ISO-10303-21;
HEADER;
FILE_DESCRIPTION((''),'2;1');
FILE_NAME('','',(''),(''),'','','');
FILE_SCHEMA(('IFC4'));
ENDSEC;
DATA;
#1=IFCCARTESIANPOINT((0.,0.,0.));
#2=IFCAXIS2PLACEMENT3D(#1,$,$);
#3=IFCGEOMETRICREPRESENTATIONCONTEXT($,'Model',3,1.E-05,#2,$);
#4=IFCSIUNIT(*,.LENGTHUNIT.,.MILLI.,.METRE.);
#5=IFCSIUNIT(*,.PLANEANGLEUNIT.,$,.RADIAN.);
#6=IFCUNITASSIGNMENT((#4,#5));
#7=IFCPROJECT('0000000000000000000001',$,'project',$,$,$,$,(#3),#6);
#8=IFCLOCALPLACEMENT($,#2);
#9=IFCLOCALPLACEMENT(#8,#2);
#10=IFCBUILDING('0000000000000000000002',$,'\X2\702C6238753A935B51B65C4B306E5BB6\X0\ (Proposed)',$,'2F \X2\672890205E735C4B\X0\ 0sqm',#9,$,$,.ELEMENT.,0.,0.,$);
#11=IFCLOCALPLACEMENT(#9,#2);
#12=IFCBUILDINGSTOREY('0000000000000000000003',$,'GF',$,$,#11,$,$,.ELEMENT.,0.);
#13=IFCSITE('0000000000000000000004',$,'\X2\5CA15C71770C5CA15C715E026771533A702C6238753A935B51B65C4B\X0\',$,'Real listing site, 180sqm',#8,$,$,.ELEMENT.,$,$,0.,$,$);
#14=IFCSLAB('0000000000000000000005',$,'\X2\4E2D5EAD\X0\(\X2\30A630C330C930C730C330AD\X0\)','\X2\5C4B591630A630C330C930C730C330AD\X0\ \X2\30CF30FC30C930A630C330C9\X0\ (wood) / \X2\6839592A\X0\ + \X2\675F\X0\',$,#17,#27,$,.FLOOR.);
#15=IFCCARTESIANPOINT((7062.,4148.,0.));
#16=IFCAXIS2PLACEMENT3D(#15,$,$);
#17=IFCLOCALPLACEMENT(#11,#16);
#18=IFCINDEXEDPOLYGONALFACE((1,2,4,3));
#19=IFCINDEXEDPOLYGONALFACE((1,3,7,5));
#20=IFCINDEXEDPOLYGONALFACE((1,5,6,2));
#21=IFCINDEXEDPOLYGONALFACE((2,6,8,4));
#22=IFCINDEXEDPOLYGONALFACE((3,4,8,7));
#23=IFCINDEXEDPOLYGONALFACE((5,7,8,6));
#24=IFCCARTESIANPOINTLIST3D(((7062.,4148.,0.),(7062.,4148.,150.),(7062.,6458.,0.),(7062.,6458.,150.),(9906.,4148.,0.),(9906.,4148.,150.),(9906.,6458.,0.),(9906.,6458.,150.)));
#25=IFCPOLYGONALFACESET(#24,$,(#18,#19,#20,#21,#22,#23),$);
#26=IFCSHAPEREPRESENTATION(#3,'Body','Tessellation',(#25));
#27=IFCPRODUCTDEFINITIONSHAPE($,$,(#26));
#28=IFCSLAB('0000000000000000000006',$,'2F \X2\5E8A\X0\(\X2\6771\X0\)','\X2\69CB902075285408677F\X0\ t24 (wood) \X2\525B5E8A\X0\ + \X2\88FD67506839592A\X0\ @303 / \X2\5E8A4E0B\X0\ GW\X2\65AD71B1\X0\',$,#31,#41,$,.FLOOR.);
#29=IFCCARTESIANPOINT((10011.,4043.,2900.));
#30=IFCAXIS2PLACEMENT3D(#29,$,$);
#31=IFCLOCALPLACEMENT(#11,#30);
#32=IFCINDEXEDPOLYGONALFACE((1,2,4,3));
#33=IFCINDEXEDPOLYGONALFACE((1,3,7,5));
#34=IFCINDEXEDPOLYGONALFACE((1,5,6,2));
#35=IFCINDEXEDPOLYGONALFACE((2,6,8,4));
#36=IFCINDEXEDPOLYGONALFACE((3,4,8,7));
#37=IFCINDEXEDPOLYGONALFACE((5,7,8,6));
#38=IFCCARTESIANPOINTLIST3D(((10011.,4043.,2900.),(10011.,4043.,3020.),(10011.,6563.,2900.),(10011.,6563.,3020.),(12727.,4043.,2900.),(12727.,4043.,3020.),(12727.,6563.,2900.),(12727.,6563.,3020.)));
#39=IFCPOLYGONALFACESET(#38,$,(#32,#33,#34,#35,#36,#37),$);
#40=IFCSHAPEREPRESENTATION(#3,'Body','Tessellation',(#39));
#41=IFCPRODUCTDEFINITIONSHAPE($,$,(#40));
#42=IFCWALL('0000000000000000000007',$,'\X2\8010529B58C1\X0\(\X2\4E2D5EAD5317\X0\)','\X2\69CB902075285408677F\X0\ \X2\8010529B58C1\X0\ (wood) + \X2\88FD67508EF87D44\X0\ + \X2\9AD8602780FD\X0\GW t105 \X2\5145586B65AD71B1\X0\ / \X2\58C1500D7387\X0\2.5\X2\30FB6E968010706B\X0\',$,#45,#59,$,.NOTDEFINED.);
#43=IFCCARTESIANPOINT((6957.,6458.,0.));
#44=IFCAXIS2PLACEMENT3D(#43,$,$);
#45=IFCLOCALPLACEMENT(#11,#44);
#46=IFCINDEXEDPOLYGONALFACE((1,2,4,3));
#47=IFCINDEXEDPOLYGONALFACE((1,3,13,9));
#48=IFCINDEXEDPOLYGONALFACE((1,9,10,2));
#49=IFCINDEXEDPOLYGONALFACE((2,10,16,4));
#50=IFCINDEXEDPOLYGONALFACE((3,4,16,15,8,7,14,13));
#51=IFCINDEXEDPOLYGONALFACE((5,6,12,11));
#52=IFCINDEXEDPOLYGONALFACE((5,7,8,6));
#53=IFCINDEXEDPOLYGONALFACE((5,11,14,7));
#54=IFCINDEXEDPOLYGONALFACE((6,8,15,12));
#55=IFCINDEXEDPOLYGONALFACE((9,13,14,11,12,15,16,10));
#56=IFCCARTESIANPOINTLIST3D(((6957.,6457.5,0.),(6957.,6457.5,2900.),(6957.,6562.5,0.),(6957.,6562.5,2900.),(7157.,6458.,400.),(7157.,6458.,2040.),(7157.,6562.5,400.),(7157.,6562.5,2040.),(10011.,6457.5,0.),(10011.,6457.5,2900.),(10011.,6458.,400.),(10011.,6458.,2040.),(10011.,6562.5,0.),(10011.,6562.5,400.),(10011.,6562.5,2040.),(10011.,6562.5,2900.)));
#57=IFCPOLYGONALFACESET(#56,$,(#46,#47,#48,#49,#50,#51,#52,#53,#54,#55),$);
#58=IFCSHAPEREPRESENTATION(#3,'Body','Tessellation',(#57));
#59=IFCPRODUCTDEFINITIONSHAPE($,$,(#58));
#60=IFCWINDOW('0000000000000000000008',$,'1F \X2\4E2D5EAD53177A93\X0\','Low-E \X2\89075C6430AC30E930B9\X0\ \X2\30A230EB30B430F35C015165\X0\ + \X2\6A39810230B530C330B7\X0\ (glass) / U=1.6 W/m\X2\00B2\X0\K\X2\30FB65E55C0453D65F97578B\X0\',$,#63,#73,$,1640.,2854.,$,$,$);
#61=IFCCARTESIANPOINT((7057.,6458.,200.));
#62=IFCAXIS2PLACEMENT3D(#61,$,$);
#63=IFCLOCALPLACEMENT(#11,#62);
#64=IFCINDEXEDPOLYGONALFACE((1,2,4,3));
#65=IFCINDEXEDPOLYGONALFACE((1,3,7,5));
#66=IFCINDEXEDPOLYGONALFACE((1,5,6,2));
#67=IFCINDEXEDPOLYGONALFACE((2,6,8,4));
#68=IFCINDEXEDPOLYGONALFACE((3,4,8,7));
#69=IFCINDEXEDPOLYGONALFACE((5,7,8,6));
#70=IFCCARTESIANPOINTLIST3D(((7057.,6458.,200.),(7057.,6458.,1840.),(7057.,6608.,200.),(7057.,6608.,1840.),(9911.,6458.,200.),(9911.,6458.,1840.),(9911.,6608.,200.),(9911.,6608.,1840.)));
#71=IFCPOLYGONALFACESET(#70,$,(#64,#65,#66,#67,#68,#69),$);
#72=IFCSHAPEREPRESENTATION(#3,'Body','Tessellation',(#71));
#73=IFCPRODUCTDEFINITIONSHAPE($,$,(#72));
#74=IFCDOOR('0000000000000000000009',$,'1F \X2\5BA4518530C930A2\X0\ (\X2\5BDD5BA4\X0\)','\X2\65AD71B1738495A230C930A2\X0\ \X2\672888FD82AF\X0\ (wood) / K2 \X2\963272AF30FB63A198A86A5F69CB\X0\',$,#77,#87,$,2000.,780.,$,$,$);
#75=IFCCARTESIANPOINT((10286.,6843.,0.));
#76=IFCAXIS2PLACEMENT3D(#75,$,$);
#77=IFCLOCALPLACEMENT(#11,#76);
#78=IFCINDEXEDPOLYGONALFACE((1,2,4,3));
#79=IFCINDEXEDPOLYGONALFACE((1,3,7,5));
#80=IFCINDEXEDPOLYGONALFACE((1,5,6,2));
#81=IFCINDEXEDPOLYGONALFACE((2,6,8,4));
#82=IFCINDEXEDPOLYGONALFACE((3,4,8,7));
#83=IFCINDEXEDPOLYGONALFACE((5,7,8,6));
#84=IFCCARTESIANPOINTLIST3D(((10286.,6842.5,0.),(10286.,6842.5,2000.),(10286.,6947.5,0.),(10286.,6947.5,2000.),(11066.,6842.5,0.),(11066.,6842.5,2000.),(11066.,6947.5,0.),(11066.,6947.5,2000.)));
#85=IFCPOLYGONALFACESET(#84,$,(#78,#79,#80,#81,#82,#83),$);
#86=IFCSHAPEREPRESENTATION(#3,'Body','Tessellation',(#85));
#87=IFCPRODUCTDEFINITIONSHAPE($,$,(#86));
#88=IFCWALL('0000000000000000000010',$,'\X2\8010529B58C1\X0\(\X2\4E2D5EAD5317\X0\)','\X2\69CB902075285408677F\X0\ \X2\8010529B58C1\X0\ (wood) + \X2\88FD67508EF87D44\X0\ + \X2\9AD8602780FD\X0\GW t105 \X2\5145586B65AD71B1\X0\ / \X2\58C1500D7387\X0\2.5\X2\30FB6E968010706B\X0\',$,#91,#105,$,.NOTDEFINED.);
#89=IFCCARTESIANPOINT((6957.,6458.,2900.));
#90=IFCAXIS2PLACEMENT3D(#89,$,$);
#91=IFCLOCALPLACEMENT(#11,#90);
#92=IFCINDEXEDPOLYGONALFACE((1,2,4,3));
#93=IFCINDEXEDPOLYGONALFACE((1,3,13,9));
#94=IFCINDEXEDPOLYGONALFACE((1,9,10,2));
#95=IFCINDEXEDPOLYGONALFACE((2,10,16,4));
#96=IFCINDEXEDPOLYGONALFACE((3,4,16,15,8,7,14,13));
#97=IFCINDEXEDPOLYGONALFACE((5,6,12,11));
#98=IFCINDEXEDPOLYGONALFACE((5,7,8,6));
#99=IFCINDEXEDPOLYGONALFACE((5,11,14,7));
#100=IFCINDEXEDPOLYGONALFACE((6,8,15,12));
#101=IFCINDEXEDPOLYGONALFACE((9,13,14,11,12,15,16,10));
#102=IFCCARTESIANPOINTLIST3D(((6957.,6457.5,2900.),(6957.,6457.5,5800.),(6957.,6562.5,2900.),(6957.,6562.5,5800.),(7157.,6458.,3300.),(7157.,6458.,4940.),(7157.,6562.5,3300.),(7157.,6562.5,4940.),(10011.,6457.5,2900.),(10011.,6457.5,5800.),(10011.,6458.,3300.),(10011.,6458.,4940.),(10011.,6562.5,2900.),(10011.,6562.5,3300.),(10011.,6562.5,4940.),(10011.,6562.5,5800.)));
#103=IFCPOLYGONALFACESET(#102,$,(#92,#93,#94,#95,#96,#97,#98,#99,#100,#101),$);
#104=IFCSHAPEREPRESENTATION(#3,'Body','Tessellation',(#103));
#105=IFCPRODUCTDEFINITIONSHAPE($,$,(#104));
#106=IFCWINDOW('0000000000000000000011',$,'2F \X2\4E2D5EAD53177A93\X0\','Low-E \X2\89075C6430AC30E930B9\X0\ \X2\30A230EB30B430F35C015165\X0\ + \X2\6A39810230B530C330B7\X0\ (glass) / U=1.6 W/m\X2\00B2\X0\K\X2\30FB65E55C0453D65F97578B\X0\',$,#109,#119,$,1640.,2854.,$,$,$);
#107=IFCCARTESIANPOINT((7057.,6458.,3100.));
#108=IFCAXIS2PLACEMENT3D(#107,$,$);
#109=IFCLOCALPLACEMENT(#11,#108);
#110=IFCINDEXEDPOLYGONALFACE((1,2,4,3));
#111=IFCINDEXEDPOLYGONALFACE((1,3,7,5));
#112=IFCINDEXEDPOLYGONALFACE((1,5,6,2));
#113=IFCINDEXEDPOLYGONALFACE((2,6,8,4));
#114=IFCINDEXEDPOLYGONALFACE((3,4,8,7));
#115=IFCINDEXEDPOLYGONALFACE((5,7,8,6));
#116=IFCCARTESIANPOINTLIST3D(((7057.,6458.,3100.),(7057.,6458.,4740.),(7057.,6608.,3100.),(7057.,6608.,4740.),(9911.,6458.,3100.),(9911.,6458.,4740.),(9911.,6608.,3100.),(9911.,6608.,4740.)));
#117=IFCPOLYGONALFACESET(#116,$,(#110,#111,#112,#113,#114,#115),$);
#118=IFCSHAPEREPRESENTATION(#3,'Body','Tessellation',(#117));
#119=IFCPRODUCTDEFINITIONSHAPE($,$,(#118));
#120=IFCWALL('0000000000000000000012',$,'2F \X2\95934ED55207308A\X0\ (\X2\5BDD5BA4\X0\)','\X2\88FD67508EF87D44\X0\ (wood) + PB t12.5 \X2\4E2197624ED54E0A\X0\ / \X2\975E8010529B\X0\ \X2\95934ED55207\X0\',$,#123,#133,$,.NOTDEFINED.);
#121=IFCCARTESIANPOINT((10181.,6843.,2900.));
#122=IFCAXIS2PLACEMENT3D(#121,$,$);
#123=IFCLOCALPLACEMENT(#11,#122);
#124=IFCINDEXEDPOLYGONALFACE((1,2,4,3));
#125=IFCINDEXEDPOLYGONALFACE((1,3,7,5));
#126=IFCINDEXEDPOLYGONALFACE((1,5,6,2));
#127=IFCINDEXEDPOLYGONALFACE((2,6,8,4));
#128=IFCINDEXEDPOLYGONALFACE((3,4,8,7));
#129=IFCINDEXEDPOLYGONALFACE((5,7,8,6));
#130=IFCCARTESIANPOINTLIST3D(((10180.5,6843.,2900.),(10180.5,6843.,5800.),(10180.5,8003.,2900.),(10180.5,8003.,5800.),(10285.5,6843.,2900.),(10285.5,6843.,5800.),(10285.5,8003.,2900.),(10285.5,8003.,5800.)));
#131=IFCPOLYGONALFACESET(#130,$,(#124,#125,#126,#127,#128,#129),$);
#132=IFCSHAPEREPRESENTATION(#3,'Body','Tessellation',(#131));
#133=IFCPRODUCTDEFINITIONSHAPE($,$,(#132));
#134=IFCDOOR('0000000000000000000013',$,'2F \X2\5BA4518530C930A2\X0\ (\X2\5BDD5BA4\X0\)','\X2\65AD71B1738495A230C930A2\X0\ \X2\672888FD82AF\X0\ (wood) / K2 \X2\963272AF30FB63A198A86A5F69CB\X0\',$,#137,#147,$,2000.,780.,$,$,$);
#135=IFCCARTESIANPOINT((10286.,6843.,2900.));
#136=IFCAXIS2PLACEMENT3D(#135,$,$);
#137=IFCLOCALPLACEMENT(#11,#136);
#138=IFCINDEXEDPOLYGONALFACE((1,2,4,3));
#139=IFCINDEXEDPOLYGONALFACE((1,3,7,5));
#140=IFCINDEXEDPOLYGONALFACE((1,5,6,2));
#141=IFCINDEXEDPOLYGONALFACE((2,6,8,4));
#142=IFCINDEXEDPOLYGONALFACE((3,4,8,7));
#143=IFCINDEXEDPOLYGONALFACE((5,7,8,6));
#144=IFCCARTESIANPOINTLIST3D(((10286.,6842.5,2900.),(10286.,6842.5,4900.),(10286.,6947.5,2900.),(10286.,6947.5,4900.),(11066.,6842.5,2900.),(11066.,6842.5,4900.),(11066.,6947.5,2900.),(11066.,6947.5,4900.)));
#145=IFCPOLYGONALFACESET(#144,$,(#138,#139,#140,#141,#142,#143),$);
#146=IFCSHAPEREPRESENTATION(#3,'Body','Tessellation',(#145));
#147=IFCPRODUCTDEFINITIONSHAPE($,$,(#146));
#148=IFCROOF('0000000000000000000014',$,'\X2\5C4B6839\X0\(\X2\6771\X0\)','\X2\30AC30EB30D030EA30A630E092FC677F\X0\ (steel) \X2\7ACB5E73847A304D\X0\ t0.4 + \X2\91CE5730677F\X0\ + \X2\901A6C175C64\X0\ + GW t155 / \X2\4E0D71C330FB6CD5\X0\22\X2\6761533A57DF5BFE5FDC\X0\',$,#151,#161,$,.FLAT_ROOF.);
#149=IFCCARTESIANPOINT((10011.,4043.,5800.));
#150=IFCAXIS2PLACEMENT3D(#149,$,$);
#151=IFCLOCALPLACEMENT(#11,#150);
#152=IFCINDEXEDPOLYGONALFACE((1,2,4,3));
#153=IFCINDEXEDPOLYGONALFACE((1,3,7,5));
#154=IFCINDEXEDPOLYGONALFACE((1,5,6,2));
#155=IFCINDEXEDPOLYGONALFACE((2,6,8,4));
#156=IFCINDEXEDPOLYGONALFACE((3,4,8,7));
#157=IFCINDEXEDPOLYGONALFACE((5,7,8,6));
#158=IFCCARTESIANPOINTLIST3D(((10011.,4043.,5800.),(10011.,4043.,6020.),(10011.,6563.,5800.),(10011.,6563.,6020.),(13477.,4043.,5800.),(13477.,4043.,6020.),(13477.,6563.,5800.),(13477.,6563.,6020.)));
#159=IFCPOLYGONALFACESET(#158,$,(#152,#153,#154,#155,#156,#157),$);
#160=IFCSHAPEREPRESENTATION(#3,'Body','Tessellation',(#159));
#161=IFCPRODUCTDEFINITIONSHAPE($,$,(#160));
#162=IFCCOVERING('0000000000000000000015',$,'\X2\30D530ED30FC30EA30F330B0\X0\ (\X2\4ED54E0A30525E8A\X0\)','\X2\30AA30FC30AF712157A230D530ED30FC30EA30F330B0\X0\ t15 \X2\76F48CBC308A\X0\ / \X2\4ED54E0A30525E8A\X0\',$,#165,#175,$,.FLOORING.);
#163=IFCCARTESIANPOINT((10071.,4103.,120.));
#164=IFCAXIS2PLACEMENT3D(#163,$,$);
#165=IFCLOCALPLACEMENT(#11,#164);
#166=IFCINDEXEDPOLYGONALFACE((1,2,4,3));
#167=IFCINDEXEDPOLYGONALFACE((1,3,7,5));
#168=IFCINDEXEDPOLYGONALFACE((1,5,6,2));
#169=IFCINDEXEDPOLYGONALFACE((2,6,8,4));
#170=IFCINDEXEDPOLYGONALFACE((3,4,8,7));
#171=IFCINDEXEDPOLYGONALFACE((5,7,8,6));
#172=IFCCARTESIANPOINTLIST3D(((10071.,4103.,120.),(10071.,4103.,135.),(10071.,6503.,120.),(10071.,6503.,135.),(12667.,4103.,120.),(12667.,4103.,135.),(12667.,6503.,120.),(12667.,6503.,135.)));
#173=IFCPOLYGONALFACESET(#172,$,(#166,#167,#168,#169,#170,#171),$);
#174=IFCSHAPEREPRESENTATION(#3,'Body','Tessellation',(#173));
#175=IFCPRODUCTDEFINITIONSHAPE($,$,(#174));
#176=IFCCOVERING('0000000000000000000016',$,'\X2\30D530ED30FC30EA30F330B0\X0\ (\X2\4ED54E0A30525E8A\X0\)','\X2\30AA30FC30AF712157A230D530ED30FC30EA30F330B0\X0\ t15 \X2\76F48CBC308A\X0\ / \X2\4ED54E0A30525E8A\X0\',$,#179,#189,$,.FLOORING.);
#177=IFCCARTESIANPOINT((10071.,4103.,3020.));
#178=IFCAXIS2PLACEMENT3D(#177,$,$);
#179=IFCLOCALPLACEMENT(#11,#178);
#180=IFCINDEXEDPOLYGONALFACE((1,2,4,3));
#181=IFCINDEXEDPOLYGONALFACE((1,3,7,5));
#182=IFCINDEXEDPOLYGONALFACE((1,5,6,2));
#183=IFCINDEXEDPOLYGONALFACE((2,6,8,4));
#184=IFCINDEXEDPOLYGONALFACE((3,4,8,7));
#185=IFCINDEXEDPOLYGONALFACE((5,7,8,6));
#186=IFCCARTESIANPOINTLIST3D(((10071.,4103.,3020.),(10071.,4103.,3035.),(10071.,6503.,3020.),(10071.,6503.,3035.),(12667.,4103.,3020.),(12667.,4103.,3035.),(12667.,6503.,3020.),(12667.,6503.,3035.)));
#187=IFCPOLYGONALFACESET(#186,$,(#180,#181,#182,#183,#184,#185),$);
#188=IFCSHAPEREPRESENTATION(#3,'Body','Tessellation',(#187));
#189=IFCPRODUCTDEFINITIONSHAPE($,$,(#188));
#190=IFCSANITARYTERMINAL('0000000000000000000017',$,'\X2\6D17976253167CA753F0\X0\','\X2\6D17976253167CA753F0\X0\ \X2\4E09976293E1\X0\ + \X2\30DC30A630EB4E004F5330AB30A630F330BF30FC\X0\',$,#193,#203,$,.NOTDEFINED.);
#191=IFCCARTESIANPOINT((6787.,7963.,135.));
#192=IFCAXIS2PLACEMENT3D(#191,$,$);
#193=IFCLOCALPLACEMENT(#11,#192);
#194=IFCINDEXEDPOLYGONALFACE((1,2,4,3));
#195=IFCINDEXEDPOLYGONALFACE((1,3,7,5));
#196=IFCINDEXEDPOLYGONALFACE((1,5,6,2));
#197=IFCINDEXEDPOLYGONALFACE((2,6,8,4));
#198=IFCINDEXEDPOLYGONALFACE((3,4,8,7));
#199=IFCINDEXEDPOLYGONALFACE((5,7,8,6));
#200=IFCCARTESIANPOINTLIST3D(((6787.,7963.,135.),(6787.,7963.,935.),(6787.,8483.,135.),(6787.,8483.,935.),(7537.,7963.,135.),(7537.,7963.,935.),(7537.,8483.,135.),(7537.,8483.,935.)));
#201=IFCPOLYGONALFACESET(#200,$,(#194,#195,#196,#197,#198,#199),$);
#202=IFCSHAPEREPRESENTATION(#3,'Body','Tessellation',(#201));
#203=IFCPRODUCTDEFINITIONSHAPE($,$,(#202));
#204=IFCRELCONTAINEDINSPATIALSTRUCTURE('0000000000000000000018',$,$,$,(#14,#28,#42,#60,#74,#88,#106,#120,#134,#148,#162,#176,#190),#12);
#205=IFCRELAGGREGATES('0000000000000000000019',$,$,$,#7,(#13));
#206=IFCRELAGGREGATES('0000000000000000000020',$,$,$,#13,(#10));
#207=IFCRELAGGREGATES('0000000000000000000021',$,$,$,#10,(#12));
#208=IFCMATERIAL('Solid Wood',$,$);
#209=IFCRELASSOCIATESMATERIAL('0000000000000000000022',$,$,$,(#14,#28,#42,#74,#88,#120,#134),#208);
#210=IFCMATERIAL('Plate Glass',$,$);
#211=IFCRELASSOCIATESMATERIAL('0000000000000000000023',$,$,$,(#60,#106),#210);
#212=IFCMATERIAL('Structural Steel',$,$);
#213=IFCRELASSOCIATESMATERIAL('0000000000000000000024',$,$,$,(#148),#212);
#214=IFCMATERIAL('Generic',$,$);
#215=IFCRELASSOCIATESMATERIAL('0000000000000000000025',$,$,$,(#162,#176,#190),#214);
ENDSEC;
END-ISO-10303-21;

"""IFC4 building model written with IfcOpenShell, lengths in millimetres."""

from ifc_helpers import new_model, si_unit, frame, frame_2d, origin, place, context, project, spatial, rectangle, extrude, material, element, fill, save


model = new_model("IFC4")

# Units and contexts
model_context = context("Model", 3, precision=1e-05, world=origin())
ifc_project = project(units=[si_unit("LENGTHUNIT", "METRE", prefix="MILLI"), si_unit("PLANEANGLEUNIT", "RADIAN")], contexts=[model_context])

# Site, building, storey
site_placement = place(None, origin())
site = spatial("IfcSite", under=ifc_project, at=site_placement, Name="岡山県岡山市東区瀬戸町鍛冶屋", ObjectType="Real listing site, 180sqm", CompositionType="ELEMENT", RefElevation=0.0)
building_placement = place(site_placement, origin())
building = spatial("IfcBuilding", under=site, at=building_placement, Name="瀬戸町鍛冶屋の家 (Proposed)", ObjectType="2F 木造平屋 0sqm", CompositionType="ELEMENT", ElevationOfRefHeight=0.0, ElevationOfTerrain=0.0)
storey_placement = place(building_placement, origin())
storey = spatial("IfcBuildingStorey", under=building, at=storey_placement, Name="GF", CompositionType="ELEMENT", Elevation=0.0)

# Slabs
ifc_material_1 = material(Name="Solid Wood")
slab_1_placement = place(storey_placement, frame((7062.0, 4148.0, 0.0)))
element("IfcSlab", 1, at=slab_1_placement, inside=storey, material=ifc_material_1, Name="中庭(ウッドデッキ)", Description="屋外ウッドデッキ ハードウッド (wood) / 根太 + 束", PredefinedType="FLOOR", context=model_context, shape_type="SweptSolid", body=[
    extrude(rectangle(XDim=2844.0, YDim=2310.0, at=frame_2d((1422.0, 1155.0))), frame((7062.0, 4148.0, 0.0)), (0.0, 0.0, 1.0), 150.0),
])
slab_2_placement = place(storey_placement, frame((10011.0, 4043.0, 2900.0)))
element("IfcSlab", 2, at=slab_2_placement, inside=storey, material=ifc_material_1, Name="2F 床(東)", Description="構造用合板 t24 (wood) 剛床 + 製材根太 @303 / 床下 GW断熱", PredefinedType="FLOOR", context=model_context, shape_type="SweptSolid", body=[
    extrude(rectangle(XDim=2716.0, YDim=2520.0, at=frame_2d((1358.0, 1260.0))), frame((10011.0, 4043.0, 2900.0)), (0.0, 0.0, 1.0), 120.0),
])

# Wall, opening, window
wall_1_placement = place(storey_placement, frame((6957.0, 6458.0, 0.0)))
wall_1 = element("IfcWall", 3, at=wall_1_placement, inside=storey, material=ifc_material_1, Name="耐力壁(中庭北)", Description="構造用合板 耐力壁 (wood) + 製材軸組 + 高性能GW t105 充填断熱 / 壁倍率2.5・準耐火", PredefinedType="NOTDEFINED", context=model_context, shape_type="SweptSolid", body=[
    extrude(rectangle(XDim=3054.0, YDim=105.0, at=frame_2d((1527.0, 52.0))), frame((6957.0, 6458.0, 0.0)), (0.0, 0.0, 1.0), 2900.0),
])
opening_1_placement = place(storey_placement, frame((7057.0, 6458.0, 200.0)))
opening_1 = element("IfcOpeningElement", 4, at=opening_1_placement, cuts=wall_1, PredefinedType="NOTDEFINED", context=model_context, shape_type="SweptSolid", body=[
    extrude(rectangle(XDim=2854.0, YDim=150.0, at=frame_2d((1427.0, 75.0))), frame((7057.0, 6458.0, 200.0)), (0.0, 0.0, 1.0), 1640.0),
])
ifc_material_2 = material(Name="Plate Glass")
window_1_placement = place(storey_placement, frame((7057.0, 6458.0, 200.0)))
window_1 = element("IfcWindow", 5, at=window_1_placement, inside=storey, material=ifc_material_2, Name="1F 中庭北窓", Description="Low-E 複層ガラス アルゴン封入 + 樹脂サッシ (glass) / U=1.6 W/m²K・日射取得型", OverallHeight=1640.0, OverallWidth=2854.0, context=model_context, shape_type="SweptSolid", body=[
    extrude(rectangle(XDim=2854.0, YDim=150.0, at=frame_2d((1427.0, 75.0))), frame((7057.0, 6458.0, 200.0)), (0.0, 0.0, 1.0), 1640.0),
])
fill(opening_1, window_1)

# Door
door_1_placement = place(storey_placement, frame((10286.0, 6843.0, 0.0)))
element("IfcDoor", 6, at=door_1_placement, inside=storey, material=ifc_material_1, Name="1F 室内ドア (寝室)", Description="断熱玄関ドア 木製芯 (wood) / K2 防犯・採風機構", OverallHeight=2000.0, OverallWidth=780.0, context=model_context, shape_type="SweptSolid", body=[
    extrude(rectangle(XDim=780.0, YDim=105.0, at=frame_2d((390.0, 52.0))), frame((10286.0, 6843.0, 0.0)), (0.0, 0.0, 1.0), 2000.0),
])

# Wall, opening, window
wall_2_placement = place(storey_placement, frame((6957.0, 6458.0, 2900.0)))
wall_2 = element("IfcWall", 7, at=wall_2_placement, inside=storey, material=ifc_material_1, Name="耐力壁(中庭北)", Description="構造用合板 耐力壁 (wood) + 製材軸組 + 高性能GW t105 充填断熱 / 壁倍率2.5・準耐火", PredefinedType="NOTDEFINED", context=model_context, shape_type="SweptSolid", body=[
    extrude(rectangle(XDim=3054.0, YDim=105.0, at=frame_2d((1527.0, 52.0))), frame((6957.0, 6458.0, 2900.0)), (0.0, 0.0, 1.0), 2900.0),
])
opening_2_placement = place(storey_placement, frame((7057.0, 6458.0, 3100.0)))
opening_2 = element("IfcOpeningElement", 8, at=opening_2_placement, cuts=wall_2, PredefinedType="NOTDEFINED", context=model_context, shape_type="SweptSolid", body=[
    extrude(rectangle(XDim=2854.0, YDim=150.0, at=frame_2d((1427.0, 75.0))), frame((7057.0, 6458.0, 3100.0)), (0.0, 0.0, 1.0), 1640.0),
])
window_2_placement = place(storey_placement, frame((7057.0, 6458.0, 3100.0)))
window_2 = element("IfcWindow", 9, at=window_2_placement, inside=storey, material=ifc_material_2, Name="2F 中庭北窓", Description="Low-E 複層ガラス アルゴン封入 + 樹脂サッシ (glass) / U=1.6 W/m²K・日射取得型", OverallHeight=1640.0, OverallWidth=2854.0, context=model_context, shape_type="SweptSolid", body=[
    extrude(rectangle(XDim=2854.0, YDim=150.0, at=frame_2d((1427.0, 75.0))), frame((7057.0, 6458.0, 3100.0)), (0.0, 0.0, 1.0), 1640.0),
])
fill(opening_2, window_2)

# Wall
wall_3_placement = place(storey_placement, frame((10181.0, 6843.0, 2900.0)))
element("IfcWall", 10, at=wall_3_placement, inside=storey, material=ifc_material_1, Name="2F 間仕切り (寝室)", Description="製材軸組 (wood) + PB t12.5 両面仕上 / 非耐力 間仕切", PredefinedType="NOTDEFINED", context=model_context, shape_type="SweptSolid", body=[
    extrude(rectangle(XDim=105.0, YDim=1160.0, at=frame_2d((52.0, 580.0))), frame((10181.0, 6843.0, 2900.0)), (0.0, 0.0, 1.0), 2900.0),
])

# Door
door_2_placement = place(storey_placement, frame((10286.0, 6843.0, 2900.0)))
element("IfcDoor", 11, at=door_2_placement, inside=storey, material=ifc_material_1, Name="2F 室内ドア (寝室)", Description="断熱玄関ドア 木製芯 (wood) / K2 防犯・採風機構", OverallHeight=2000.0, OverallWidth=780.0, context=model_context, shape_type="SweptSolid", body=[
    extrude(rectangle(XDim=780.0, YDim=105.0, at=frame_2d((390.0, 52.0))), frame((10286.0, 6843.0, 2900.0)), (0.0, 0.0, 1.0), 2000.0),
])

# Roof
ifc_material_3 = material(Name="Structural Steel")
for number, where, name in (
    (12, (10011.0, 4043.0, 5800.0), "屋根(東)"),
):
    element("IfcRoof", number, at=place(storey_placement, frame(where)), inside=storey, material=ifc_material_3, Name=name, Description="ガルバリウム鋼板 (steel) 立平葺き t0.4 + 野地板 + 通気層 + GW t155 / 不燃・法22条区域対応", PredefinedType="FLAT_ROOF", context=model_context, shape_type="SweptSolid", body=[
        extrude(rectangle(XDim=3466.0, YDim=2520.0, at=frame_2d((1733.0, 1260.0))), frame((10011.0, 4043.0, 5800.0)), (0.0, 0.0, 1.0), 220.0),
    ])

# Coverings
ifc_material_4 = material(Name="Generic")
covering_1_placement = place(storey_placement, frame((10071.0, 4103.0, 120.0)))
element("IfcCovering", 13, at=covering_1_placement, inside=storey, material=ifc_material_4, Name="フローリング (仕上げ床)", Description="オーク無垢フローリング t15 直貼り / 仕上げ床", PredefinedType="FLOORING", context=model_context, shape_type="SweptSolid", body=[
    extrude(rectangle(XDim=2596.0, YDim=2400.0, at=frame_2d((1298.0, 1200.0))), frame((10071.0, 4103.0, 120.0)), (0.0, 0.0, 1.0), 15.0),
])
covering_2_placement = place(storey_placement, frame((10071.0, 4103.0, 3020.0)))
element("IfcCovering", 14, at=covering_2_placement, inside=storey, material=ifc_material_4, Name="フローリング (仕上げ床)", Description="オーク無垢フローリング t15 直貼り / 仕上げ床", PredefinedType="FLOORING", context=model_context, shape_type="SweptSolid", body=[
    extrude(rectangle(XDim=2596.0, YDim=2400.0, at=frame_2d((1298.0, 1200.0))), frame((10071.0, 4103.0, 3020.0)), (0.0, 0.0, 1.0), 15.0),
])

# Sanitary terminal
sanitary_terminal_1_placement = place(storey_placement, frame((6787.0, 7963.0, 135.0)))
element("IfcSanitaryTerminal", 15, at=sanitary_terminal_1_placement, inside=storey, material=ifc_material_4, Name="洗面化粧台", Description="洗面化粧台 三面鏡 + ボウル一体カウンター", PredefinedType="NOTDEFINED", context=model_context, shape_type="SweptSolid", body=[
    extrude(rectangle(XDim=750.0, YDim=520.0, at=frame_2d((375.0, 260.0))), frame((6787.0, 7963.0, 135.0)), (0.0, 0.0, 1.0), 800.0),
])

save(model, "model.ifc")
